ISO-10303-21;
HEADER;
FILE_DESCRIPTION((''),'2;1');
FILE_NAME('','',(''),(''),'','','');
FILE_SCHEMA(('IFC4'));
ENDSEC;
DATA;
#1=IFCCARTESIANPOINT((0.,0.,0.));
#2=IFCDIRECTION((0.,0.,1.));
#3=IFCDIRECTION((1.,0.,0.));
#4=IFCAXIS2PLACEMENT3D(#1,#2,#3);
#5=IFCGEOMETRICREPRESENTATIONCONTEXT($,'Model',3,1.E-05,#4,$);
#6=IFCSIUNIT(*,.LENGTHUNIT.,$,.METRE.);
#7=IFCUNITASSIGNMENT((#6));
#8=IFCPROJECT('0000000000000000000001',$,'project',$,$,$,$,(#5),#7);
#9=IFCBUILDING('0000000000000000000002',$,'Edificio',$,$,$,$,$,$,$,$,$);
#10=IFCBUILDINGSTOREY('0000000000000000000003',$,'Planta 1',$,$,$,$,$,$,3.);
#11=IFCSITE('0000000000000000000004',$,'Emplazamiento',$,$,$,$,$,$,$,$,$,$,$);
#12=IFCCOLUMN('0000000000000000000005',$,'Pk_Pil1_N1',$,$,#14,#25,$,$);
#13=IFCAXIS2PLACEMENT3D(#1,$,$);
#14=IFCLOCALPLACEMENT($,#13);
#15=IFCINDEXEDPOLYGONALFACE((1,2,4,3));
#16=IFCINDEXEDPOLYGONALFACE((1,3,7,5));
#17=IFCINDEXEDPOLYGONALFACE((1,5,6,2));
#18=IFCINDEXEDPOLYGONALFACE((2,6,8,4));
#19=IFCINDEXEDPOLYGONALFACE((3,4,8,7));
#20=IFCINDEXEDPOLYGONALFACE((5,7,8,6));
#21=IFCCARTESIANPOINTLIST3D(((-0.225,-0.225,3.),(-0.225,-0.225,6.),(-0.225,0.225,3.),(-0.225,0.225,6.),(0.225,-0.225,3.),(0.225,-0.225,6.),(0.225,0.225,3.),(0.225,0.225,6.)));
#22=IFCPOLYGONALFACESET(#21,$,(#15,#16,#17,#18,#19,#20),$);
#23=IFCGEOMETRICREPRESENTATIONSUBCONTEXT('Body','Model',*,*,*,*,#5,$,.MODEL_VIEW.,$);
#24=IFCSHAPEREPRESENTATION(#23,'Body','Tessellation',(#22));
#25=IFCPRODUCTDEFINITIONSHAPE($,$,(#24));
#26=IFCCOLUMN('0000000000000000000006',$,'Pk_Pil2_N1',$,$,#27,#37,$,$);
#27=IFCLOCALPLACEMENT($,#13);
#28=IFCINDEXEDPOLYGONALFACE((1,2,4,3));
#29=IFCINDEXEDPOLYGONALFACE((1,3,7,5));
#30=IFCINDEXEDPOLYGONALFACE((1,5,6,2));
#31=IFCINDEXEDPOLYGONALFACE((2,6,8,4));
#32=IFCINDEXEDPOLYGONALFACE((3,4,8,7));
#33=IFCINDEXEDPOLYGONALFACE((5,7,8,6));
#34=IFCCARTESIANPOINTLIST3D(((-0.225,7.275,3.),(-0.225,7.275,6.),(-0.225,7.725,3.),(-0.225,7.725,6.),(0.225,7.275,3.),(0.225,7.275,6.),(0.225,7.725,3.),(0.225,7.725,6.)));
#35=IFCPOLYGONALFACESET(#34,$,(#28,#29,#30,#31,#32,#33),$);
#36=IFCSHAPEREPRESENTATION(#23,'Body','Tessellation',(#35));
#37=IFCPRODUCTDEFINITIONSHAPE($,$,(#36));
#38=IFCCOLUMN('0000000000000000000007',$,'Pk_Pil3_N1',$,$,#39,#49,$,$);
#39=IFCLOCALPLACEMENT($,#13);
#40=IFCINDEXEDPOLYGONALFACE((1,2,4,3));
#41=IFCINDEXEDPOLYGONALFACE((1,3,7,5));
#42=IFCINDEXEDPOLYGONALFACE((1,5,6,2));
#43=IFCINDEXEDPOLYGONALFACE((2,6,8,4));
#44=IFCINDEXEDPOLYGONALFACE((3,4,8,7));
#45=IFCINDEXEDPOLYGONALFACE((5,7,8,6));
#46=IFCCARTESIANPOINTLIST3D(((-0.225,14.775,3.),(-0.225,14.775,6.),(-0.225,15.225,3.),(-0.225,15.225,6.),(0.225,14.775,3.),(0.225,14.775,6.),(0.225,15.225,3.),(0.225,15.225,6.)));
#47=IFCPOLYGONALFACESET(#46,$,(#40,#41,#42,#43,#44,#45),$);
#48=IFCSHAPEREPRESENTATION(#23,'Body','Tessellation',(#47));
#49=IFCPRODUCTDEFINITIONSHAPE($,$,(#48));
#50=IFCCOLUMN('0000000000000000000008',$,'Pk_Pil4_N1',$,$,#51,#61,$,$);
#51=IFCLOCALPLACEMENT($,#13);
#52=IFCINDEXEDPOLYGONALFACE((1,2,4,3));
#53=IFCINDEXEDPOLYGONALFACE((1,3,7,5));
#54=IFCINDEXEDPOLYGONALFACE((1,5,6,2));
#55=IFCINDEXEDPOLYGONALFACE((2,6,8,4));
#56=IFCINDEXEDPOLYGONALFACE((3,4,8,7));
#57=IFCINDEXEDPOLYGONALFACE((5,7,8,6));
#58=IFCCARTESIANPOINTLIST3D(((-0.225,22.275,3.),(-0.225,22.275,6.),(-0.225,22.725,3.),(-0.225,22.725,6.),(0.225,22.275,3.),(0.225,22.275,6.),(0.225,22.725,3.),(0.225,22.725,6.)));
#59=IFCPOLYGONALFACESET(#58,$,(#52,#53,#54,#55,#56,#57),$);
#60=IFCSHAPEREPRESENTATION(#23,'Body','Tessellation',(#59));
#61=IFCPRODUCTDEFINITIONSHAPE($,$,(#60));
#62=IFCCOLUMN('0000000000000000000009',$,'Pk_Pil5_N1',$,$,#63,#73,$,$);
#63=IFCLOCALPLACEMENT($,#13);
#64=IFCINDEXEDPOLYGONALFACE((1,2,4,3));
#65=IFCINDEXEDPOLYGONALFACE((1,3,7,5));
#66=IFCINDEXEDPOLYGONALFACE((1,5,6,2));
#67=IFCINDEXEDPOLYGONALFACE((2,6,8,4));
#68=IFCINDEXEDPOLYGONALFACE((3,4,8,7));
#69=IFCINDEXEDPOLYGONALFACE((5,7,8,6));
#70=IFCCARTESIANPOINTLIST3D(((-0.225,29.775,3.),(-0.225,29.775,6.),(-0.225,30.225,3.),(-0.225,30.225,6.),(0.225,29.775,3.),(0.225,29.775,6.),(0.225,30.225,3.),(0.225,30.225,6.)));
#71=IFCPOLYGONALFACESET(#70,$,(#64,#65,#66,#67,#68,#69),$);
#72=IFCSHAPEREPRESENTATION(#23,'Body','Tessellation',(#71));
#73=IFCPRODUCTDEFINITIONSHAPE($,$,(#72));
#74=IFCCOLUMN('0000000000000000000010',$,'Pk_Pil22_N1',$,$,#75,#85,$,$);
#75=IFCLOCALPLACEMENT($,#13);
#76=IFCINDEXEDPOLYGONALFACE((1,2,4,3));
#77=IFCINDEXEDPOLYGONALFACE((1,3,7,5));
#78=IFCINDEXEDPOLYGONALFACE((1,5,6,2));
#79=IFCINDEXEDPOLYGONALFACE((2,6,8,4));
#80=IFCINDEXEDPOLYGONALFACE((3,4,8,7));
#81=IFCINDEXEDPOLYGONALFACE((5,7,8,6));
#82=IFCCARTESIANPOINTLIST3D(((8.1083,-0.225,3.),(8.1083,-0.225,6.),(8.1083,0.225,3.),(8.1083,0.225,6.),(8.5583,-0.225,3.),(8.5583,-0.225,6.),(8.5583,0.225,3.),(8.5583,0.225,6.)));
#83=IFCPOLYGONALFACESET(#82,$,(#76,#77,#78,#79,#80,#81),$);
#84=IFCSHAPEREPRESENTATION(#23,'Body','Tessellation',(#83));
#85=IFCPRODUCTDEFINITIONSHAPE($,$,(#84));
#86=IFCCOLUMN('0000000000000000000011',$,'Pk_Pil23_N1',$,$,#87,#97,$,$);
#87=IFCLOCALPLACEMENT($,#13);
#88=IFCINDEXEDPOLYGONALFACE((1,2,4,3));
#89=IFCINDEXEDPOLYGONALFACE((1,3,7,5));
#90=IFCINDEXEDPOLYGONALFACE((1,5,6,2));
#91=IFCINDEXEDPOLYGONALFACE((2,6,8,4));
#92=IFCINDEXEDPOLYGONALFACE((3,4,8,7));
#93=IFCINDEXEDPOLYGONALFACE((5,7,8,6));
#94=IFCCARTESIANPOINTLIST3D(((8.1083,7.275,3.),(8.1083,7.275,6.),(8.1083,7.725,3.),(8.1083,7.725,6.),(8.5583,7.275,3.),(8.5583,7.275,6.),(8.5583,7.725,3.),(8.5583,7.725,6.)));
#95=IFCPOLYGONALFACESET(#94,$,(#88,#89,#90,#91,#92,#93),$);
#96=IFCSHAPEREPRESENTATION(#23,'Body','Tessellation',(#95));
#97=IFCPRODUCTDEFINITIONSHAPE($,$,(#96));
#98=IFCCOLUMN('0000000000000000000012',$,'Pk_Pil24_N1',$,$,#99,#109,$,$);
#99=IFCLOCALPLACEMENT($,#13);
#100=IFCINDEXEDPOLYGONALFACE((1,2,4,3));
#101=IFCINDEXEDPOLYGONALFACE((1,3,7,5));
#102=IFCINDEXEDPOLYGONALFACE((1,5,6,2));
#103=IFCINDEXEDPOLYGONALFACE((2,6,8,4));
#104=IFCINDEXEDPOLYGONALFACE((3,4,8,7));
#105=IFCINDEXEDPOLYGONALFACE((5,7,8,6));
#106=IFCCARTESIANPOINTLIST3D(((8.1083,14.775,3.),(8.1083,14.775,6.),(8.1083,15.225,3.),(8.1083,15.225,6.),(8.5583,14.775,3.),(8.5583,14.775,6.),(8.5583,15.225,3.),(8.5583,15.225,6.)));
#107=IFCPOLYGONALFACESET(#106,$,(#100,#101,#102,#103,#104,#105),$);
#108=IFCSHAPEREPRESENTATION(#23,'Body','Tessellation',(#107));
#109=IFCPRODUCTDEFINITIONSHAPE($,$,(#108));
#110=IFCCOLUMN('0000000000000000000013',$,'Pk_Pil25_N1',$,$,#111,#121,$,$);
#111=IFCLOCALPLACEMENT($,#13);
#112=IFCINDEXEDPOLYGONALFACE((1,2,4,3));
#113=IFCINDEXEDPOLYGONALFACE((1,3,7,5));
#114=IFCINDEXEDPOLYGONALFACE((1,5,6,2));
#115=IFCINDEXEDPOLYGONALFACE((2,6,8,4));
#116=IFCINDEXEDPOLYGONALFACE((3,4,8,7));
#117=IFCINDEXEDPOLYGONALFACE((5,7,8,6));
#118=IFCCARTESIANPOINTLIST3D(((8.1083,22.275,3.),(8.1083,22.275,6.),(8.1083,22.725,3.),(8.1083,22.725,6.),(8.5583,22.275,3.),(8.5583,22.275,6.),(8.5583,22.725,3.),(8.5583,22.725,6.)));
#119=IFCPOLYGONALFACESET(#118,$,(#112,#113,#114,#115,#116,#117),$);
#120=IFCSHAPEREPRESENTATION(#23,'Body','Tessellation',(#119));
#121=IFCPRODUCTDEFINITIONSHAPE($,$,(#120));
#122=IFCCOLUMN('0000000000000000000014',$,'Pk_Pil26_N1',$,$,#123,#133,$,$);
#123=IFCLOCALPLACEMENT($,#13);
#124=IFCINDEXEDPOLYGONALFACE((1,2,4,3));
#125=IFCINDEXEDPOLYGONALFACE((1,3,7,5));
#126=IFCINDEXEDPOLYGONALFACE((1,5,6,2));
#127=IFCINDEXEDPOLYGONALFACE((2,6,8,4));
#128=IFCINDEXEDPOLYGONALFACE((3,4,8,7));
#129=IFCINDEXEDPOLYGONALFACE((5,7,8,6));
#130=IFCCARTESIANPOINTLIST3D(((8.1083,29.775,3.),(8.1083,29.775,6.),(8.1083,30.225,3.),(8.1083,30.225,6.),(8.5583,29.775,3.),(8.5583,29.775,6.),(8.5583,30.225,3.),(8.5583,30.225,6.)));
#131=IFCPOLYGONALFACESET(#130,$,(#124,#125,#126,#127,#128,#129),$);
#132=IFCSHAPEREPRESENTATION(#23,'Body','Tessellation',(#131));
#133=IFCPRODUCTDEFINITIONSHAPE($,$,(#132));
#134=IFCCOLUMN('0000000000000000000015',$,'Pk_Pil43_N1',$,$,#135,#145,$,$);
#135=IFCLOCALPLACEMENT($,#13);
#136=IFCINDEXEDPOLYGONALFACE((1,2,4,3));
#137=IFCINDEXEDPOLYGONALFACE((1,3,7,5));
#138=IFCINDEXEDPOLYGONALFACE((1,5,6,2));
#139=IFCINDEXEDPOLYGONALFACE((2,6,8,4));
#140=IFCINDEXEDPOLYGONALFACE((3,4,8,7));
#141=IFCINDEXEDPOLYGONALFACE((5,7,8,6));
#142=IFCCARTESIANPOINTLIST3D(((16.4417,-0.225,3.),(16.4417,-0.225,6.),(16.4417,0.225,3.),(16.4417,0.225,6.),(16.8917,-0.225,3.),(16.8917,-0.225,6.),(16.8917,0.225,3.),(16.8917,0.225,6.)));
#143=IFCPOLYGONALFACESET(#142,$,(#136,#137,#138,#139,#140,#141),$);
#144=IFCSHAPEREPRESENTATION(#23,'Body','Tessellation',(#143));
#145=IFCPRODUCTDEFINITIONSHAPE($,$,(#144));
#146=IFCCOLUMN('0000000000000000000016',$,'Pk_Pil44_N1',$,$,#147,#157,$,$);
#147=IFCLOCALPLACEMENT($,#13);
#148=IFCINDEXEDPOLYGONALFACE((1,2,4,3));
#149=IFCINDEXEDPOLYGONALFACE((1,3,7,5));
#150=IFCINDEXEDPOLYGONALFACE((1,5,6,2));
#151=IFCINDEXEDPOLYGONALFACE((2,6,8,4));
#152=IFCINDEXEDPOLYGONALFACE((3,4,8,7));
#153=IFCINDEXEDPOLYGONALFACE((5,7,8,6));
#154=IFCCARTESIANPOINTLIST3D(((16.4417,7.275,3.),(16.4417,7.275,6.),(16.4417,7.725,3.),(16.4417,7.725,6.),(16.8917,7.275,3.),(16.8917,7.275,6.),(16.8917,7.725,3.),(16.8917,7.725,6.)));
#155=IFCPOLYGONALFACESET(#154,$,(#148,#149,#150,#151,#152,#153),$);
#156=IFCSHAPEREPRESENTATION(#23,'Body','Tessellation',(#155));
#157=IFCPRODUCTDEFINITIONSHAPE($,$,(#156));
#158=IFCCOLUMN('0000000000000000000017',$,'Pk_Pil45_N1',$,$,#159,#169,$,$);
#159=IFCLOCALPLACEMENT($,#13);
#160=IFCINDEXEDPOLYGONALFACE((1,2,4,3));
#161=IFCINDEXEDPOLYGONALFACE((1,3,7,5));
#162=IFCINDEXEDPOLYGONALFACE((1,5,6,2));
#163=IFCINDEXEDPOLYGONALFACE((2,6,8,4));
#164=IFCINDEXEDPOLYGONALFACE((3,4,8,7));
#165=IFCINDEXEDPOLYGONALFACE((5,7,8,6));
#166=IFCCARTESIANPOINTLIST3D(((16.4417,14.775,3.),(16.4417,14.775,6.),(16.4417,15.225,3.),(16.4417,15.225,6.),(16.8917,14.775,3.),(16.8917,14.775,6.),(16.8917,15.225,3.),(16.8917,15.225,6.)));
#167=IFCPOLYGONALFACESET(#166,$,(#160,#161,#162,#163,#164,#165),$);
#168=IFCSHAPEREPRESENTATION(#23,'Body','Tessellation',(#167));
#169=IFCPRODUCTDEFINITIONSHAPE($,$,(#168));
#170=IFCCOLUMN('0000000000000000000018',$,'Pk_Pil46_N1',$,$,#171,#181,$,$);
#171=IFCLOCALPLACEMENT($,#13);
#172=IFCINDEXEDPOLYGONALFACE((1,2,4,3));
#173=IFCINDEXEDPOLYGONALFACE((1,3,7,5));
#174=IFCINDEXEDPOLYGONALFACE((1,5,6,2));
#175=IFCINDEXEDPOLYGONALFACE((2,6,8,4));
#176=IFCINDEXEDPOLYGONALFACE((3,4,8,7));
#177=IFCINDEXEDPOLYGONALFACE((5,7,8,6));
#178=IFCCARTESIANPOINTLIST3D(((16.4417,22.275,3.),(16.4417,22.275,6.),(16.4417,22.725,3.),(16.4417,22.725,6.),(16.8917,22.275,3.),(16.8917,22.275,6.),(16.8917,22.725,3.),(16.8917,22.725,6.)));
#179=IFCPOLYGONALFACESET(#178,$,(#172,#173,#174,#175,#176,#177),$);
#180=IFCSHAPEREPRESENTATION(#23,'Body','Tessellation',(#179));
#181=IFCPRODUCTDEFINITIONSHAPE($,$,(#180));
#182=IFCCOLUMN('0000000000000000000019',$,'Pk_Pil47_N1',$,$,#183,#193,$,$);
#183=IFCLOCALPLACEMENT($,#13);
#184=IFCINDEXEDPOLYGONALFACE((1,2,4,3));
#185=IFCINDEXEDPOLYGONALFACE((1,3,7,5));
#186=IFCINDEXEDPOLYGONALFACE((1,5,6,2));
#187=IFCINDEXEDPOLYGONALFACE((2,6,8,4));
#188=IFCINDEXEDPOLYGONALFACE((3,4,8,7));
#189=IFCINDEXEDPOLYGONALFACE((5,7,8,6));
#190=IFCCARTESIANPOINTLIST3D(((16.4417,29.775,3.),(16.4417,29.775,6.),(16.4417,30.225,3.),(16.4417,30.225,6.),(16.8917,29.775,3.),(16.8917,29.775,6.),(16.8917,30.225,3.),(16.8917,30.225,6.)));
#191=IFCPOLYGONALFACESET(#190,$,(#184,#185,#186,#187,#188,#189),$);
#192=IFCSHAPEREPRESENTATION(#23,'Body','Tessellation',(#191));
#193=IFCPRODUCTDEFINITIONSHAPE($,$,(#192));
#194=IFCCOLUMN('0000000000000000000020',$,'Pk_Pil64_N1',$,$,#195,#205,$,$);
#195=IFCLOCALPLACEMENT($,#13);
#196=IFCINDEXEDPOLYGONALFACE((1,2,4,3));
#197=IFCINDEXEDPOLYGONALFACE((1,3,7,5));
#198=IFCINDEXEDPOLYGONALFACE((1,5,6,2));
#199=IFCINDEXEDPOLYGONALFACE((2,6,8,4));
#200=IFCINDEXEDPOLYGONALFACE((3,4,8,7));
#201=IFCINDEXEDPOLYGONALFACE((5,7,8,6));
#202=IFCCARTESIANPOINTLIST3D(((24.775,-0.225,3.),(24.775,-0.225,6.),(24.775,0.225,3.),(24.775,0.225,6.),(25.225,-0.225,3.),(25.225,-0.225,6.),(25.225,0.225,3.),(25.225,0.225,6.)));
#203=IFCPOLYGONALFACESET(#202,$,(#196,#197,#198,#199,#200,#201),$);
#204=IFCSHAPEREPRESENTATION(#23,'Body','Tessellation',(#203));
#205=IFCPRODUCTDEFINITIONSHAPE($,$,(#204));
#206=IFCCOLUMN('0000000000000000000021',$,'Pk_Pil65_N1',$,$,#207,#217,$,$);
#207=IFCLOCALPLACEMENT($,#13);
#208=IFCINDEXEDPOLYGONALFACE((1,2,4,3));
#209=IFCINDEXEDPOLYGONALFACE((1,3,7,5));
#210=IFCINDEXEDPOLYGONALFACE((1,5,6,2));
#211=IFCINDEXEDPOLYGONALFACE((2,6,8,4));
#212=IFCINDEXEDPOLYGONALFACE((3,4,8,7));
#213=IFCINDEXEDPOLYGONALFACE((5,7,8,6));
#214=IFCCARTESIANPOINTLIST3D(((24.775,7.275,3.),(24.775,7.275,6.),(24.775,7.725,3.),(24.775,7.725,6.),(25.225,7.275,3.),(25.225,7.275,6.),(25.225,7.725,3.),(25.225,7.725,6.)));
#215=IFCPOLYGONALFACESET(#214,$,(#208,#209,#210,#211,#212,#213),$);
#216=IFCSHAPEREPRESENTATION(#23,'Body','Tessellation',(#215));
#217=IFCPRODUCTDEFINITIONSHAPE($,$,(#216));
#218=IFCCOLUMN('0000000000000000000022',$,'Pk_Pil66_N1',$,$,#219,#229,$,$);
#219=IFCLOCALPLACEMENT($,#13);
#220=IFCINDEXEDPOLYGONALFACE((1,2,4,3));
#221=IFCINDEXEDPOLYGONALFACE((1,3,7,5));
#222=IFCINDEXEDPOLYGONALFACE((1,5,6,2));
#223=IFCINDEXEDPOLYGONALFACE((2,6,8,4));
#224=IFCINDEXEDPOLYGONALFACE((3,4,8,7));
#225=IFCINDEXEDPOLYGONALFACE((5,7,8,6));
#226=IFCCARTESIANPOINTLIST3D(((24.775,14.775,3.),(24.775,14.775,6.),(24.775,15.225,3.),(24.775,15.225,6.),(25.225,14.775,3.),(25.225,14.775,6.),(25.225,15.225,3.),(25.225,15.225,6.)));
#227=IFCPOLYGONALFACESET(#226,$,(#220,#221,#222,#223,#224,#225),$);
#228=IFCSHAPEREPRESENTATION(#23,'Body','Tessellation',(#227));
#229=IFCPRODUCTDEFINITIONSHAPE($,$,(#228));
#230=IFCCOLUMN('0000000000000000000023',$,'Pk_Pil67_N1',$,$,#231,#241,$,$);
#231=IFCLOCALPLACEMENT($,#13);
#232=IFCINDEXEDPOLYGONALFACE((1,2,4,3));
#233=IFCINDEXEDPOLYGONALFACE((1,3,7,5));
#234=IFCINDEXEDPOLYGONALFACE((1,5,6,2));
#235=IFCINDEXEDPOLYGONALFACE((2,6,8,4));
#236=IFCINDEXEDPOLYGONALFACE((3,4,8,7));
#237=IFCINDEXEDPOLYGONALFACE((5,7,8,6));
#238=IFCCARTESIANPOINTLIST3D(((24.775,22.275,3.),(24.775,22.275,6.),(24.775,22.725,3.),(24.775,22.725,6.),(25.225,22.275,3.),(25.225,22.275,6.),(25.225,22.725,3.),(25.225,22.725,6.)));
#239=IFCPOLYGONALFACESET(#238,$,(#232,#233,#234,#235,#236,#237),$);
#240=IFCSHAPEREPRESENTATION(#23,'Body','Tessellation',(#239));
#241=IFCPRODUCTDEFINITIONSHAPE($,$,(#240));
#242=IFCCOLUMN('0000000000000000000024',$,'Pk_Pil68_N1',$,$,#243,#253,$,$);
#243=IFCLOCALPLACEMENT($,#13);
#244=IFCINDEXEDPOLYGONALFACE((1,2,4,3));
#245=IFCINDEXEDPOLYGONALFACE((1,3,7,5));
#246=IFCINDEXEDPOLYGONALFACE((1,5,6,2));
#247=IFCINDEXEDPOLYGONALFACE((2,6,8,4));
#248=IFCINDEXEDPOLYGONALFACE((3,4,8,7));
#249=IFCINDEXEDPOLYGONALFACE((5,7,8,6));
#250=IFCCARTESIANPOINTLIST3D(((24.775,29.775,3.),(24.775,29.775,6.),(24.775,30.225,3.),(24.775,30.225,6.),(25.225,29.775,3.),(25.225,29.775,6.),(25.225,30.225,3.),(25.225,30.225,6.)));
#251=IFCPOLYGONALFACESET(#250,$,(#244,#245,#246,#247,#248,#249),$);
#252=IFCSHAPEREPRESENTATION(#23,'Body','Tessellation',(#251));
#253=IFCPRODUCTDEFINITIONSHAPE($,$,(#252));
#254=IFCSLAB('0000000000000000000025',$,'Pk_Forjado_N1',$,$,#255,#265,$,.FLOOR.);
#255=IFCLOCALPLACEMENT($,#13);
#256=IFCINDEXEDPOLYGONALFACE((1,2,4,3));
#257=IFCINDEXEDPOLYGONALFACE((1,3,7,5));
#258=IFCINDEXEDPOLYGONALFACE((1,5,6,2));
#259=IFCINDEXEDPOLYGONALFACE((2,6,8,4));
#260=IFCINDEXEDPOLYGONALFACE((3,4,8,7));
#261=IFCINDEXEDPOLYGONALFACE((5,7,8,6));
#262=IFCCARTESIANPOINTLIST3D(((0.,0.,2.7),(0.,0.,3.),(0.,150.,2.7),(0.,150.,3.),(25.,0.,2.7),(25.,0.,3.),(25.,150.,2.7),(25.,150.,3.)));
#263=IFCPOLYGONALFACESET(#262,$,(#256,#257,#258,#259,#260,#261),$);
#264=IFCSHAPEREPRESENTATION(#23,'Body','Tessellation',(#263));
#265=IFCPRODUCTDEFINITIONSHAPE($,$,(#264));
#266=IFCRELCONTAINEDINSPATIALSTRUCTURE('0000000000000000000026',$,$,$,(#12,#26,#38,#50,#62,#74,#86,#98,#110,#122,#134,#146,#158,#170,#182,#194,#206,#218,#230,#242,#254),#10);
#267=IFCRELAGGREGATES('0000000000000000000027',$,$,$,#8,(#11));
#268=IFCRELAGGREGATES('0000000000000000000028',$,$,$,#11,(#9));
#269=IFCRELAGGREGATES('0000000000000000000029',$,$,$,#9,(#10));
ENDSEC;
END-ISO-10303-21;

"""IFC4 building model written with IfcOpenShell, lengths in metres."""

from ifc_helpers import new_model, si_unit, frame, origin_with_axes, origin_2d, place, context, subcontext, project, spatial, polyline, rectangle, outline, extrude, element, save


model = new_model("IFC4")

# Units and contexts
model_context = context("Model", 3, precision=1e-05, world=origin_with_axes())
body_context = subcontext(model_context, "Body", "Model", "MODEL_VIEW")
ifc_project = project(units=[si_unit("LENGTHUNIT", "METRE")], contexts=[model_context])

# Site, building, storey
site = spatial("IfcSite", under=ifc_project, Name="Emplazamiento")
building = spatial("IfcBuilding", under=site, Name="Edificio")
storey = spatial("IfcBuildingStorey", under=building, Name="Planta 1", Elevation=3.0)

# Columns
for number, where, z_axis, x_axis, name in (
    (1, (0.0, 0.0, 3.0), (0.0, 0.0, 1.0), (1.0, 0.0, 0.0), "Pk_Pil1_N1"),
    (2, (0.0, 7.5, 3.0), (0.0, 0.0, 1.0), (1.0, 0.0, 0.0), "Pk_Pil2_N1"),
    (3, (0.0, 15.0, 3.0), (0.0, 0.0, 1.0), (1.0, 0.0, 0.0), "Pk_Pil3_N1"),
    (4, (0.0, 22.5, 3.0), (0.0, 0.0, 1.0), (1.0, 0.0, 0.0), "Pk_Pil4_N1"),
    (5, (0.0, 30.0, 3.0), (0.0, 0.0, 1.0), (1.0, 0.0, 0.0), "Pk_Pil5_N1"),
    (6, (8.3333, 0.0, 3.0), (0.0, 0.0, 1.0), (1.0, 0.0, 0.0), "Pk_Pil22_N1"),
    (7, (8.3333, 7.5, 3.0), (0.0, 0.0, 1.0), (1.0, 0.0, 0.0), "Pk_Pil23_N1"),
    (8, (8.3333, 15.0, 3.0), (0.0, 0.0, 1.0), (1.0, 0.0, 0.0), "Pk_Pil24_N1"),
    (9, (8.3333, 22.5, 3.0), (0.0, 0.0, 1.0), (1.0, 0.0, 0.0), "Pk_Pil25_N1"),
    (10, (8.3333, 30.0, 3.0), (0.0, 0.0, 1.0), (1.0, 0.0, 0.0), "Pk_Pil26_N1"),
    (11, (16.6667, 0.0, 3.0), (0.0, 0.0, 1.0), (1.0, 0.0, 0.0), "Pk_Pil43_N1"),
    (12, (16.6667, 7.5, 3.0), (0.0, 0.0, 1.0), (1.0, 0.0, 0.0), "Pk_Pil44_N1"),
    (13, (16.6667, 15.0, 3.0), (0.0, 0.0, 1.0), (1.0, 0.0, 0.0), "Pk_Pil45_N1"),
    (14, (16.6667, 22.5, 3.0), (0.0, 0.0, 1.0), (1.0, 0.0, 0.0), "Pk_Pil46_N1"),
    (15, (16.6667, 30.0, 3.0), (0.0, 0.0, 1.0), (1.0, 0.0, 0.0), "Pk_Pil47_N1"),
    (16, (25.0, 0.0, 3.0), (0.0, 0.0, 1.0), (1.0, 0.0, 0.0), "Pk_Pil64_N1"),
    (17, (25.0, 7.5, 3.0), (0.0, 0.0, 1.0), (1.0, 0.0, 0.0), "Pk_Pil65_N1"),
    (18, (25.0, 15.0, 3.0), (0.0, 0.0, 1.0), (1.0, 0.0, 0.0), "Pk_Pil66_N1"),
    (19, (25.0, 22.5, 3.0), (0.0, 0.0, 1.0), (1.0, 0.0, 0.0), "Pk_Pil67_N1"),
    (20, (25.0, 30.0, 3.0), (0.0, 0.0, 1.0), (1.0, 0.0, 0.0), "Pk_Pil68_N1"),
):
    element("IfcColumn", number, at=place(None, frame(where, z_axis=z_axis, x_axis=x_axis)), inside=storey, Name=name, context=body_context, shape_type="SweptSolid", body=[
        extrude(rectangle(XDim=0.45, YDim=0.45, at=origin_2d()), origin_with_axes(), (0.0, 0.0, 1.0), 3.0),
    ])

# Slab
slab_placement = place(None, frame((0.0, 0.0, 3.0), z_axis=(0.0, 0.0, 1.0), x_axis=(1.0, 0.0, 0.0)))
element("IfcSlab", 21, at=slab_placement, inside=storey, Name="Pk_Forjado_N1", PredefinedType="FLOOR", context=body_context, shape_type="SweptSolid", body=[
    extrude(outline(polyline([(0.0, 0.0), (25.0, 0.0), (25.0, 150.0), (0.0, 150.0), (0.0, 0.0)])), frame((0.0, 0.0, -0.3), z_axis=(0.0, 0.0, 1.0), x_axis=(1.0, 0.0, 0.0)), (0.0, 0.0, 1.0), 0.3),
])

save(model, "model.ifc")
